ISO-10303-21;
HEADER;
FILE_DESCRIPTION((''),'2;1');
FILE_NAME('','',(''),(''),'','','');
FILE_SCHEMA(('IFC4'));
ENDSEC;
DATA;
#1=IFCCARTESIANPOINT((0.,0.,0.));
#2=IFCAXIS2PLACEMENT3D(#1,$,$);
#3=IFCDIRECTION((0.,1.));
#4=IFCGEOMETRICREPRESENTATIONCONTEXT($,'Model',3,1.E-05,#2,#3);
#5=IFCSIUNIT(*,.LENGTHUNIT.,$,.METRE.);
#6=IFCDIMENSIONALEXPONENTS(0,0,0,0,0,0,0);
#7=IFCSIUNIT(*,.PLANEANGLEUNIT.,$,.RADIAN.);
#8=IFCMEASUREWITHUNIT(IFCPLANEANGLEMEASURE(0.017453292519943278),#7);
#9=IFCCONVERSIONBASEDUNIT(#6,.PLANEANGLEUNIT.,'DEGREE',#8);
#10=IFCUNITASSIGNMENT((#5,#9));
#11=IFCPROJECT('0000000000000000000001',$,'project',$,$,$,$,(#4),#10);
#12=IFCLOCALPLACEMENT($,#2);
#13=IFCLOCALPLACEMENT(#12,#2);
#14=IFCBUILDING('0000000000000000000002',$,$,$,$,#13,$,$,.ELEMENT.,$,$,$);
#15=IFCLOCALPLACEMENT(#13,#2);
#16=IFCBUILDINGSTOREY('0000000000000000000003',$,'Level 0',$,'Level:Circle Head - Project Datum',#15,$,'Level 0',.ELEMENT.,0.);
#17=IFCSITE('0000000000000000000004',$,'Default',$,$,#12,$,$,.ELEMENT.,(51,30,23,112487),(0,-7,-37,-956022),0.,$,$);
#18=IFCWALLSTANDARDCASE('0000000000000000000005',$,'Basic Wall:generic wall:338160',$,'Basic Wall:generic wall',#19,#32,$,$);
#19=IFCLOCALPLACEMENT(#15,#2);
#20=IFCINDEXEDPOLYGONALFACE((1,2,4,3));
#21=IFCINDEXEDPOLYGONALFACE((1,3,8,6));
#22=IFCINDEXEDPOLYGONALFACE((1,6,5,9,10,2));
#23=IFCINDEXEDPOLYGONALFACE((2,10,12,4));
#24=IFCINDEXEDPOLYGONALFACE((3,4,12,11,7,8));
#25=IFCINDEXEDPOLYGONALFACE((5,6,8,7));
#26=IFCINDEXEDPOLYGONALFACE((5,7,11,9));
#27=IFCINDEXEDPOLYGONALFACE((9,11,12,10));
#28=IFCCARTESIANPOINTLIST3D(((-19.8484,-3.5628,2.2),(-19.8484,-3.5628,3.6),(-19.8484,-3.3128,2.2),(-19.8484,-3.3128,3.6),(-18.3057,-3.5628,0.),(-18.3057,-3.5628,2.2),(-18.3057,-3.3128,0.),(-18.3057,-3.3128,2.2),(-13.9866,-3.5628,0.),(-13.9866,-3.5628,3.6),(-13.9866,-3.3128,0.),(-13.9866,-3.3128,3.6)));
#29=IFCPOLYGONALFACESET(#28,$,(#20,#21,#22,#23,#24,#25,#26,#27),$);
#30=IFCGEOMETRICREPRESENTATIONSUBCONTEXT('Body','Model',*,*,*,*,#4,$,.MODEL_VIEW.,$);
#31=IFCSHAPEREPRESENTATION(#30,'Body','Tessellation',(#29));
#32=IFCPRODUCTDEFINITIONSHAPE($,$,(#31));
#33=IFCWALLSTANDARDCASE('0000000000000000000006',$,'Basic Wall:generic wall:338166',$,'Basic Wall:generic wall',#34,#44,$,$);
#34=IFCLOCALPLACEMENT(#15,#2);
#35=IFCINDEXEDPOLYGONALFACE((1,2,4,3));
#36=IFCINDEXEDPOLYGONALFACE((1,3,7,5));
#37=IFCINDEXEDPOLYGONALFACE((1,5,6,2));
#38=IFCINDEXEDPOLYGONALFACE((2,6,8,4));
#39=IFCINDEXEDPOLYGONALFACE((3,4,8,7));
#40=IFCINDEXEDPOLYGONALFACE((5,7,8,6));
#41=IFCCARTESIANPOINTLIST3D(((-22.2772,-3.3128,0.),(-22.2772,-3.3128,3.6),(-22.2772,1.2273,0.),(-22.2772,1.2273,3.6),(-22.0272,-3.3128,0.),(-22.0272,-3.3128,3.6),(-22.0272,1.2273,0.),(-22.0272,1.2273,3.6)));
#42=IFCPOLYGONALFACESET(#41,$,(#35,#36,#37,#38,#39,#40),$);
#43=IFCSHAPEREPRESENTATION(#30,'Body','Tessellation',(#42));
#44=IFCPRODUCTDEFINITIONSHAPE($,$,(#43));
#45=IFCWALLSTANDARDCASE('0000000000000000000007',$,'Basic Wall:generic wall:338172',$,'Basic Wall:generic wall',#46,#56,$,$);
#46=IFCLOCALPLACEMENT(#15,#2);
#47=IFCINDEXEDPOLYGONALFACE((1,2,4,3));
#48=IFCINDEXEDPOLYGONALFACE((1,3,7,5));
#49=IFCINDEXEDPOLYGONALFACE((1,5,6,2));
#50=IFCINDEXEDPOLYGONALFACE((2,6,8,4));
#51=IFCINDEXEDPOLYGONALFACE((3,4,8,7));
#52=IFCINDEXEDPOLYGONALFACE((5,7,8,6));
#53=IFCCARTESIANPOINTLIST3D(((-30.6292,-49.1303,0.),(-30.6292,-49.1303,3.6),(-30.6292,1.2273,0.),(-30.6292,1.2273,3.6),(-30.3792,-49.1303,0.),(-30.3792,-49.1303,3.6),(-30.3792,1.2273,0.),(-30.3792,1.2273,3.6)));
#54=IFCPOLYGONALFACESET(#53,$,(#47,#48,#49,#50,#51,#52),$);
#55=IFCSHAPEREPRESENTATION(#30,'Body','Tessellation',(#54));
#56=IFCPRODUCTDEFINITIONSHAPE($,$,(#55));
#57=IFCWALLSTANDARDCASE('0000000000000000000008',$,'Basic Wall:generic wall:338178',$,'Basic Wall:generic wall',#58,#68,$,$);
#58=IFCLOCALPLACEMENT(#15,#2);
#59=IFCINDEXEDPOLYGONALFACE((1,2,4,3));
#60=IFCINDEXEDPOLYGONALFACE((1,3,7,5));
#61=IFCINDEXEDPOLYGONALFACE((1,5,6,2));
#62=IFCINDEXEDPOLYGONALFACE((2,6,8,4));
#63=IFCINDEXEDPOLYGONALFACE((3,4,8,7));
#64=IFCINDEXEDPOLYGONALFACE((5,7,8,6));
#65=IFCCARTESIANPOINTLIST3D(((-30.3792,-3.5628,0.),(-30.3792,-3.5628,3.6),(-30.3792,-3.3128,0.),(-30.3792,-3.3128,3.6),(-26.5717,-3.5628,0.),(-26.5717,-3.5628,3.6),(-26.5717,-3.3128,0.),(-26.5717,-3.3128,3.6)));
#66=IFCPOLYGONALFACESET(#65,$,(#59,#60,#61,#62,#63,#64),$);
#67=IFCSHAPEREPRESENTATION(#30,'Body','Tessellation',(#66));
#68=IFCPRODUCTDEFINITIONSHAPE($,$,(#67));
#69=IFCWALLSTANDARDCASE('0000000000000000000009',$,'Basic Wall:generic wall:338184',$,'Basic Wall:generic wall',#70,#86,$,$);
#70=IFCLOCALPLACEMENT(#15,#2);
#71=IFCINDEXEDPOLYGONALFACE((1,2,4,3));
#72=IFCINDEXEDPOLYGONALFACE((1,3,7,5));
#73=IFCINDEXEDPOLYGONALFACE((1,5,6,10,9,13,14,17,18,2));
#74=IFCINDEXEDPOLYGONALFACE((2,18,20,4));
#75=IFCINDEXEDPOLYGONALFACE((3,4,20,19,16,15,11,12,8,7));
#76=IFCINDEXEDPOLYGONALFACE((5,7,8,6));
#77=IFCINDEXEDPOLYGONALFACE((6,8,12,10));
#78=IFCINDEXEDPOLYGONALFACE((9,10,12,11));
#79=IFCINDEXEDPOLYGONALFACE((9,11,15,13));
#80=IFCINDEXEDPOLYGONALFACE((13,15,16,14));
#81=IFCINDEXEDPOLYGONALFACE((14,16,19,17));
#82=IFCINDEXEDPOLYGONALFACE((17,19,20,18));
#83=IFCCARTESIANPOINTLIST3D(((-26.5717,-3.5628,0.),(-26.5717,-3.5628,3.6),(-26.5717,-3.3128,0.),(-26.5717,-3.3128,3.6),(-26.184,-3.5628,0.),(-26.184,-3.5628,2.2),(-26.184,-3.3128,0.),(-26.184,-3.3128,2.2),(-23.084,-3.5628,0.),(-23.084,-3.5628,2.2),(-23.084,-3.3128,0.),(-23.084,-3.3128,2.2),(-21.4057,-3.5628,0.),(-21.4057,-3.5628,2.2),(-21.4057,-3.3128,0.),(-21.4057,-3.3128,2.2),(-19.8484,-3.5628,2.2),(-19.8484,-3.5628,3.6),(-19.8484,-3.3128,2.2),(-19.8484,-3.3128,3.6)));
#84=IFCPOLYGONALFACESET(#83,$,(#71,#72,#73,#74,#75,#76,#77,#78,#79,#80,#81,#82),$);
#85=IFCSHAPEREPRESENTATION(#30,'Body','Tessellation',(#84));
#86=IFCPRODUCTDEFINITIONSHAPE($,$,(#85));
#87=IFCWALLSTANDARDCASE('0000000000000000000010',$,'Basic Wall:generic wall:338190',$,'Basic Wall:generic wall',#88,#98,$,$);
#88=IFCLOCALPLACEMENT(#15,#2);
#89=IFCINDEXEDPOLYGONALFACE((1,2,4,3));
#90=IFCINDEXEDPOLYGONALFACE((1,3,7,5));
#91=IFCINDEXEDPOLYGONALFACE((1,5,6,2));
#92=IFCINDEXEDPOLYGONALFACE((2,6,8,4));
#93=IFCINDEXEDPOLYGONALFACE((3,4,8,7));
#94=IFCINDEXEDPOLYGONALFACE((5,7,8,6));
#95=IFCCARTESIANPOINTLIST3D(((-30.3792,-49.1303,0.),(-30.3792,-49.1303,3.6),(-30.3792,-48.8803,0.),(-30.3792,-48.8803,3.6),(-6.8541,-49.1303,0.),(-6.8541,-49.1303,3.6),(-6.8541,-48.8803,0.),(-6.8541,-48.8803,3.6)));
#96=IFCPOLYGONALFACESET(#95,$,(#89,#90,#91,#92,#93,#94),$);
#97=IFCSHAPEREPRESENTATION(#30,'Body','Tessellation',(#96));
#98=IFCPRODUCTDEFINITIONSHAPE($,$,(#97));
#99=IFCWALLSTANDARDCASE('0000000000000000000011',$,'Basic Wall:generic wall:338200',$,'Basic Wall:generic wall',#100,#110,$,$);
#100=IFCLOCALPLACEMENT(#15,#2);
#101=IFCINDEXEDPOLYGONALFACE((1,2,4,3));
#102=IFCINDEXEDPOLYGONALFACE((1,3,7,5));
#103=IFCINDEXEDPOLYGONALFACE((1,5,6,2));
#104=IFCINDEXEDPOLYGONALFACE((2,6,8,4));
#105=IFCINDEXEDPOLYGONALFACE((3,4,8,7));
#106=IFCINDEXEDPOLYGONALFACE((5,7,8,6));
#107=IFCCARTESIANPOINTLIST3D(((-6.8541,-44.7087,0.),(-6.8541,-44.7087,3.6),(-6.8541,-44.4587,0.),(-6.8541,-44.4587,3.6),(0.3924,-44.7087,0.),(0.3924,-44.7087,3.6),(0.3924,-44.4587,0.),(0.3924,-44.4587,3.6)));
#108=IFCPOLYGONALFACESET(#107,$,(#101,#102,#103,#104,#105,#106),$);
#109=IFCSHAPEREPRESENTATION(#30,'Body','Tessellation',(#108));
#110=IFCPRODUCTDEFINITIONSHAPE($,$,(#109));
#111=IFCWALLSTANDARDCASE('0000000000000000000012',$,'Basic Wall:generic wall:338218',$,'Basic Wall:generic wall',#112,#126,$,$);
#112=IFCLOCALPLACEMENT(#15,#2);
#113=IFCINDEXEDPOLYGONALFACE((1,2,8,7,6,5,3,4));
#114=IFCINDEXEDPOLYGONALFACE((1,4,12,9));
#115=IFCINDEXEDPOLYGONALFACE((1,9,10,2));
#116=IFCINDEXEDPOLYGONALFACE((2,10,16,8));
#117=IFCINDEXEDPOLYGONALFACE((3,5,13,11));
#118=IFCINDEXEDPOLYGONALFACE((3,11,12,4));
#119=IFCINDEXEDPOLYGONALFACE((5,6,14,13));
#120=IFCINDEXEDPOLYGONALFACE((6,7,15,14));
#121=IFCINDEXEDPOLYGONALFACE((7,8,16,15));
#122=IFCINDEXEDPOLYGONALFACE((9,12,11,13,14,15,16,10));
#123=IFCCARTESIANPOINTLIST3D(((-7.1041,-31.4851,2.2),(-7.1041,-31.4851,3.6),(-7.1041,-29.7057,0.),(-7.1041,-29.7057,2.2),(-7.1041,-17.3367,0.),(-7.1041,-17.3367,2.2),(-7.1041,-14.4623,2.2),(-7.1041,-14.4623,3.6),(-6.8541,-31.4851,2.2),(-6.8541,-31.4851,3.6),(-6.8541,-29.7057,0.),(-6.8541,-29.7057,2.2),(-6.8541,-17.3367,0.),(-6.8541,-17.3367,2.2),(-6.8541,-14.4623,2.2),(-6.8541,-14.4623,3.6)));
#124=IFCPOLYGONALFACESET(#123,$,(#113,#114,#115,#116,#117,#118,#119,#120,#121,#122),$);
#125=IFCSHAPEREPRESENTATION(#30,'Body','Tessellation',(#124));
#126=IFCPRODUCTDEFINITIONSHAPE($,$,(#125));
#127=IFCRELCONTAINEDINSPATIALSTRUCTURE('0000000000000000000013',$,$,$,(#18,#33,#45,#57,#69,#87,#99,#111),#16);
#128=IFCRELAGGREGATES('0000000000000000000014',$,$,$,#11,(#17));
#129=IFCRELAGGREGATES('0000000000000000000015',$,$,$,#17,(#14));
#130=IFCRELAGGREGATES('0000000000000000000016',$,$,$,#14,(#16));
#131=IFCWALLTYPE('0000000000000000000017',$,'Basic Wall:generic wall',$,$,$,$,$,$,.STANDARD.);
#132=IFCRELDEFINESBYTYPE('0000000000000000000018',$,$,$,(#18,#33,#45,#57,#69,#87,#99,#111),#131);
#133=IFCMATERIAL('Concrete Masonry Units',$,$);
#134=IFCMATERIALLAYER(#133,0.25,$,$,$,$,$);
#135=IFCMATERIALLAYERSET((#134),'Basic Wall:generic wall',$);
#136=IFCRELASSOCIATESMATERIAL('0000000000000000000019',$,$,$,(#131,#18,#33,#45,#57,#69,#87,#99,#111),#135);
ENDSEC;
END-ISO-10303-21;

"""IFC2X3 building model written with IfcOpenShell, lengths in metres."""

from ifc_helpers import new_model, entity, si_unit, converted_unit, direction, frame, frame_2d, origin, place, context, subcontext, project, spatial, rectangle, extrude, material, layer, layer_set, layer_usage, type_object, element, save


model = new_model("IFC2X3")

# Units and contexts
model_context = context("Model", 3, precision=1e-05, world=origin(), true_north=direction((0.0, 1.0)))
body_context = subcontext(model_context, "Body", "Model", "MODEL_VIEW")
ifc_project = project(units=[si_unit("LENGTHUNIT", "METRE"), converted_unit("PLANEANGLEUNIT", "DEGREE", entity("IfcPlaneAngleMeasure", 0.017453292519943278), si_unit("PLANEANGLEUNIT", "RADIAN"), dimensions=[0, 0, 0, 0, 0, 0, 0])], contexts=[model_context])

# Site, building, storey
site_placement = place(None, origin())
site = spatial("IfcSite", under=ifc_project, at=site_placement, Name="Default", CompositionType="ELEMENT", RefLatitude=(51, 30, 23, 112487), RefLongitude=(0, -7, -37, -956022), RefElevation=0.0)
building_placement = place(site_placement, origin())
building = spatial("IfcBuilding", under=site, at=building_placement, CompositionType="ELEMENT")
storey_placement = place(building_placement, origin())
storey = spatial("IfcBuildingStorey", under=building, at=storey_placement, Name="Level 0", ObjectType="Level:Circle Head - Project Datum", LongName="Level 0", CompositionType="ELEMENT", Elevation=0.0)

# Shared definitions
ifc_material = material(Name="Concrete Masonry Units")
ifc_layer = layer(ifc_material, 0.25)
ifc_layer_set = layer_set([ifc_layer], Name="Basic Wall:generic wall")
wall_type = type_object("IfcWallType", Name="Basic Wall:generic wall", PredefinedType="STANDARD", material=ifc_layer_set)

# Wall, opening
ifc_layer_usage_1 = layer_usage(ifc_layer_set, "AXIS2", "NEGATIVE", 0.125)
wall_1_placement = place(storey_placement, frame((-13.9866, -3.4378, 0.0), z_axis=(0.0, 0.0, 1.0), x_axis=(-1.0, 0.0, 0.0)))
wall_1 = element("IfcWallStandardCase", 1, at=wall_1_placement, inside=storey, type_object=wall_type, material=ifc_layer_usage_1, Name="Basic Wall:generic wall:338160", ObjectType="Basic Wall:generic wall", context=body_context, shape_type="SweptSolid", body=[
    extrude(rectangle(XDim=5.8618, YDim=0.25, at=frame_2d((2.9309, 0.0), x_axis=(-1.0, 0.0))), origin(), (0.0, 0.0, 1.0), 3.6),
])
opening_1_placement = place(wall_1_placement, frame((7.4191, 0.125, 0.0)))
element("IfcOpeningElement", 2, at=opening_1_placement, cuts=wall_1, ObjectType="Opening", context=body_context, shape_type="SweptSolid", body=[
    extrude(rectangle(XDim=2.2, YDim=3.1, at=frame_2d((1.1, 1.55), x_axis=(1.0, 0.0))), frame((0.0, 0.0, 0.0), z_axis=(0.0, -1.0, 0.0), x_axis=(0.0, 0.0, 1.0)), (0.0, 0.0, 1.0), 0.25),
])

# Walls
ifc_layer_usage_2 = layer_usage(ifc_layer_set, "AXIS2", "NEGATIVE", 0.125)
wall_2_placement = place(storey_placement, frame((-22.1522, 1.2273, 0.0), z_axis=(0.0, 0.0, 1.0), x_axis=(0.0, -1.0, 0.0)))
element("IfcWallStandardCase", 3, at=wall_2_placement, inside=storey, type_object=wall_type, material=ifc_layer_usage_2, Name="Basic Wall:generic wall:338166", ObjectType="Basic Wall:generic wall", context=body_context, shape_type="SweptSolid", body=[
    extrude(rectangle(XDim=4.5401, YDim=0.25, at=frame_2d((2.2701, 0.0), x_axis=(-1.0, 0.0))), origin(), (0.0, 0.0, 1.0), 3.6),
])
ifc_layer_usage_3 = layer_usage(ifc_layer_set, "AXIS2", "NEGATIVE", 0.125)
wall_3_placement = place(storey_placement, frame((-30.5042, 1.2273, 0.0), z_axis=(0.0, 0.0, 1.0), x_axis=(0.0, -1.0, 0.0)))
element("IfcWallStandardCase", 4, at=wall_3_placement, inside=storey, type_object=wall_type, material=ifc_layer_usage_3, Name="Basic Wall:generic wall:338172", ObjectType="Basic Wall:generic wall", context=body_context, shape_type="SweptSolid", body=[
    extrude(rectangle(XDim=50.3576, YDim=0.25, at=frame_2d((25.1788, 0.0), x_axis=(-1.0, 0.0))), origin(), (0.0, 0.0, 1.0), 3.6),
])
ifc_layer_usage_4 = layer_usage(ifc_layer_set, "AXIS2", "NEGATIVE", 0.125)
wall_4_placement = place(storey_placement, frame((-30.3792, -3.4378, 0.0)))
element("IfcWallStandardCase", 5, at=wall_4_placement, inside=storey, type_object=wall_type, material=ifc_layer_usage_4, Name="Basic Wall:generic wall:338178", ObjectType="Basic Wall:generic wall", context=body_context, shape_type="SweptSolid", body=[
    extrude(rectangle(XDim=3.8075, YDim=0.25, at=frame_2d((1.9038, 0.0), x_axis=(-1.0, 0.0))), origin(), (0.0, 0.0, 1.0), 3.6),
])

# Wall, openings
ifc_layer_usage_5 = layer_usage(ifc_layer_set, "AXIS2", "NEGATIVE", 0.125)
wall_5_placement = place(storey_placement, frame((-19.8484, -3.4378, 0.0), z_axis=(0.0, 0.0, 1.0), x_axis=(-1.0, 0.0, 0.0)))
wall_5 = element("IfcWallStandardCase", 6, at=wall_5_placement, inside=storey, type_object=wall_type, material=ifc_layer_usage_5, Name="Basic Wall:generic wall:338184", ObjectType="Basic Wall:generic wall", context=body_context, shape_type="SweptSolid", body=[
    extrude(rectangle(XDim=6.7233, YDim=0.25, at=frame_2d((3.3616, 0.0), x_axis=(1.0, 0.0))), origin(), (0.0, 0.0, 1.0), 3.6),
])
opening_2_placement = place(wall_5_placement, origin())
element("IfcOpeningElement", 7, at=opening_2_placement, cuts=wall_5, ObjectType="Opening", context=body_context, shape_type="SweptSolid", body=[
    extrude(rectangle(XDim=2.2, YDim=3.1, at=frame_2d((0.0, 0.0), x_axis=(1.0, 0.0))), frame((0.0073, -1.399, 1.1), z_axis=(0.0, 1.0, 0.0), x_axis=(0.0, 0.0, 1.0)), (0.0, 0.0, 1.0), 3.048),
])
opening_3_placement = place(wall_5_placement, frame((6.3356, 0.125, 0.0)))
element("IfcOpeningElement", 8, at=opening_3_placement, cuts=wall_5, ObjectType="Opening", context=body_context, shape_type="SweptSolid", body=[
    extrude(rectangle(XDim=2.2, YDim=3.1, at=frame_2d((1.1, 1.55), x_axis=(1.0, 0.0))), frame((0.0, 0.0, 0.0), z_axis=(0.0, -1.0, 0.0), x_axis=(0.0, 0.0, 1.0)), (0.0, 0.0, 1.0), 0.25),
])

# Wall
ifc_layer_usage_6 = layer_usage(ifc_layer_set, "AXIS2", "NEGATIVE", 0.125)
wall_6_placement = place(storey_placement, frame((-30.3792, -49.0053, 0.0)))
element("IfcWallStandardCase", 9, at=wall_6_placement, inside=storey, type_object=wall_type, material=ifc_layer_usage_6, Name="Basic Wall:generic wall:338190", ObjectType="Basic Wall:generic wall", context=body_context, shape_type="SweptSolid", body=[
    extrude(rectangle(XDim=23.5251, YDim=0.25, at=frame_2d((11.7625, 0.0), x_axis=(-1.0, 0.0))), origin(), (0.0, 0.0, 1.0), 3.6),
])

# Wall
ifc_layer_usage_7 = layer_usage(ifc_layer_set, "AXIS2", "NEGATIVE", 0.125)
wall_7_placement = place(storey_placement, frame((-6.8541, -44.5837, 0.0)))
element("IfcWallStandardCase", 10, at=wall_7_placement, inside=storey, type_object=wall_type, material=ifc_layer_usage_7, Name="Basic Wall:generic wall:338200", ObjectType="Basic Wall:generic wall", context=body_context, shape_type="SweptSolid", body=[
    extrude(rectangle(XDim=7.2466, YDim=0.25, at=frame_2d((3.6233, 0.0), x_axis=(-1.0, 0.0))), origin(), (0.0, 0.0, 1.0), 3.6),
])

# Wall, openings
ifc_layer_usage_8 = layer_usage(ifc_layer_set, "AXIS2", "NEGATIVE", 0.125)
wall_8_placement = place(storey_placement, frame((-6.9791, -31.4851, 0.0), z_axis=(0.0, 0.0, 1.0), x_axis=(0.0, 1.0, 0.0)))
wall_8 = element("IfcWallStandardCase", 11, at=wall_8_placement, inside=storey, type_object=wall_type, material=ifc_layer_usage_8, Name="Basic Wall:generic wall:338218", ObjectType="Basic Wall:generic wall", context=body_context, shape_type="SweptSolid", body=[
    extrude(rectangle(XDim=17.0228, YDim=0.25, at=frame_2d((8.5114, 0.0), x_axis=(-1.0, 0.0))), origin(), (0.0, 0.0, 1.0), 3.6),
])
opening_4_placement = place(wall_8_placement, frame((17.2484, 0.125, 0.0)))
element("IfcOpeningElement", 12, at=opening_4_placement, cuts=wall_8, ObjectType="Opening", context=body_context, shape_type="SweptSolid", body=[
    extrude(rectangle(XDim=2.2, YDim=3.1, at=frame_2d((1.1, 1.55), x_axis=(1.0, 0.0))), frame((0.0, 0.0, 0.0), z_axis=(0.0, -1.0, 0.0), x_axis=(0.0, 0.0, 1.0)), (0.0, 0.0, 1.0), 0.25),
])
opening_5_placement = place(wall_8_placement, frame((1.7793, 0.125, 0.0)))
element("IfcOpeningElement", 13, at=opening_5_placement, cuts=wall_8, ObjectType="Opening", context=body_context, shape_type="SweptSolid", body=[
    extrude(rectangle(XDim=2.2, YDim=3.1, at=frame_2d((1.1, 1.55), x_axis=(1.0, 0.0))), frame((0.0, 0.0, 0.0), z_axis=(0.0, -1.0, 0.0), x_axis=(0.0, 0.0, 1.0)), (0.0, 0.0, 1.0), 0.25),
])

save(model, "model.ifc")
